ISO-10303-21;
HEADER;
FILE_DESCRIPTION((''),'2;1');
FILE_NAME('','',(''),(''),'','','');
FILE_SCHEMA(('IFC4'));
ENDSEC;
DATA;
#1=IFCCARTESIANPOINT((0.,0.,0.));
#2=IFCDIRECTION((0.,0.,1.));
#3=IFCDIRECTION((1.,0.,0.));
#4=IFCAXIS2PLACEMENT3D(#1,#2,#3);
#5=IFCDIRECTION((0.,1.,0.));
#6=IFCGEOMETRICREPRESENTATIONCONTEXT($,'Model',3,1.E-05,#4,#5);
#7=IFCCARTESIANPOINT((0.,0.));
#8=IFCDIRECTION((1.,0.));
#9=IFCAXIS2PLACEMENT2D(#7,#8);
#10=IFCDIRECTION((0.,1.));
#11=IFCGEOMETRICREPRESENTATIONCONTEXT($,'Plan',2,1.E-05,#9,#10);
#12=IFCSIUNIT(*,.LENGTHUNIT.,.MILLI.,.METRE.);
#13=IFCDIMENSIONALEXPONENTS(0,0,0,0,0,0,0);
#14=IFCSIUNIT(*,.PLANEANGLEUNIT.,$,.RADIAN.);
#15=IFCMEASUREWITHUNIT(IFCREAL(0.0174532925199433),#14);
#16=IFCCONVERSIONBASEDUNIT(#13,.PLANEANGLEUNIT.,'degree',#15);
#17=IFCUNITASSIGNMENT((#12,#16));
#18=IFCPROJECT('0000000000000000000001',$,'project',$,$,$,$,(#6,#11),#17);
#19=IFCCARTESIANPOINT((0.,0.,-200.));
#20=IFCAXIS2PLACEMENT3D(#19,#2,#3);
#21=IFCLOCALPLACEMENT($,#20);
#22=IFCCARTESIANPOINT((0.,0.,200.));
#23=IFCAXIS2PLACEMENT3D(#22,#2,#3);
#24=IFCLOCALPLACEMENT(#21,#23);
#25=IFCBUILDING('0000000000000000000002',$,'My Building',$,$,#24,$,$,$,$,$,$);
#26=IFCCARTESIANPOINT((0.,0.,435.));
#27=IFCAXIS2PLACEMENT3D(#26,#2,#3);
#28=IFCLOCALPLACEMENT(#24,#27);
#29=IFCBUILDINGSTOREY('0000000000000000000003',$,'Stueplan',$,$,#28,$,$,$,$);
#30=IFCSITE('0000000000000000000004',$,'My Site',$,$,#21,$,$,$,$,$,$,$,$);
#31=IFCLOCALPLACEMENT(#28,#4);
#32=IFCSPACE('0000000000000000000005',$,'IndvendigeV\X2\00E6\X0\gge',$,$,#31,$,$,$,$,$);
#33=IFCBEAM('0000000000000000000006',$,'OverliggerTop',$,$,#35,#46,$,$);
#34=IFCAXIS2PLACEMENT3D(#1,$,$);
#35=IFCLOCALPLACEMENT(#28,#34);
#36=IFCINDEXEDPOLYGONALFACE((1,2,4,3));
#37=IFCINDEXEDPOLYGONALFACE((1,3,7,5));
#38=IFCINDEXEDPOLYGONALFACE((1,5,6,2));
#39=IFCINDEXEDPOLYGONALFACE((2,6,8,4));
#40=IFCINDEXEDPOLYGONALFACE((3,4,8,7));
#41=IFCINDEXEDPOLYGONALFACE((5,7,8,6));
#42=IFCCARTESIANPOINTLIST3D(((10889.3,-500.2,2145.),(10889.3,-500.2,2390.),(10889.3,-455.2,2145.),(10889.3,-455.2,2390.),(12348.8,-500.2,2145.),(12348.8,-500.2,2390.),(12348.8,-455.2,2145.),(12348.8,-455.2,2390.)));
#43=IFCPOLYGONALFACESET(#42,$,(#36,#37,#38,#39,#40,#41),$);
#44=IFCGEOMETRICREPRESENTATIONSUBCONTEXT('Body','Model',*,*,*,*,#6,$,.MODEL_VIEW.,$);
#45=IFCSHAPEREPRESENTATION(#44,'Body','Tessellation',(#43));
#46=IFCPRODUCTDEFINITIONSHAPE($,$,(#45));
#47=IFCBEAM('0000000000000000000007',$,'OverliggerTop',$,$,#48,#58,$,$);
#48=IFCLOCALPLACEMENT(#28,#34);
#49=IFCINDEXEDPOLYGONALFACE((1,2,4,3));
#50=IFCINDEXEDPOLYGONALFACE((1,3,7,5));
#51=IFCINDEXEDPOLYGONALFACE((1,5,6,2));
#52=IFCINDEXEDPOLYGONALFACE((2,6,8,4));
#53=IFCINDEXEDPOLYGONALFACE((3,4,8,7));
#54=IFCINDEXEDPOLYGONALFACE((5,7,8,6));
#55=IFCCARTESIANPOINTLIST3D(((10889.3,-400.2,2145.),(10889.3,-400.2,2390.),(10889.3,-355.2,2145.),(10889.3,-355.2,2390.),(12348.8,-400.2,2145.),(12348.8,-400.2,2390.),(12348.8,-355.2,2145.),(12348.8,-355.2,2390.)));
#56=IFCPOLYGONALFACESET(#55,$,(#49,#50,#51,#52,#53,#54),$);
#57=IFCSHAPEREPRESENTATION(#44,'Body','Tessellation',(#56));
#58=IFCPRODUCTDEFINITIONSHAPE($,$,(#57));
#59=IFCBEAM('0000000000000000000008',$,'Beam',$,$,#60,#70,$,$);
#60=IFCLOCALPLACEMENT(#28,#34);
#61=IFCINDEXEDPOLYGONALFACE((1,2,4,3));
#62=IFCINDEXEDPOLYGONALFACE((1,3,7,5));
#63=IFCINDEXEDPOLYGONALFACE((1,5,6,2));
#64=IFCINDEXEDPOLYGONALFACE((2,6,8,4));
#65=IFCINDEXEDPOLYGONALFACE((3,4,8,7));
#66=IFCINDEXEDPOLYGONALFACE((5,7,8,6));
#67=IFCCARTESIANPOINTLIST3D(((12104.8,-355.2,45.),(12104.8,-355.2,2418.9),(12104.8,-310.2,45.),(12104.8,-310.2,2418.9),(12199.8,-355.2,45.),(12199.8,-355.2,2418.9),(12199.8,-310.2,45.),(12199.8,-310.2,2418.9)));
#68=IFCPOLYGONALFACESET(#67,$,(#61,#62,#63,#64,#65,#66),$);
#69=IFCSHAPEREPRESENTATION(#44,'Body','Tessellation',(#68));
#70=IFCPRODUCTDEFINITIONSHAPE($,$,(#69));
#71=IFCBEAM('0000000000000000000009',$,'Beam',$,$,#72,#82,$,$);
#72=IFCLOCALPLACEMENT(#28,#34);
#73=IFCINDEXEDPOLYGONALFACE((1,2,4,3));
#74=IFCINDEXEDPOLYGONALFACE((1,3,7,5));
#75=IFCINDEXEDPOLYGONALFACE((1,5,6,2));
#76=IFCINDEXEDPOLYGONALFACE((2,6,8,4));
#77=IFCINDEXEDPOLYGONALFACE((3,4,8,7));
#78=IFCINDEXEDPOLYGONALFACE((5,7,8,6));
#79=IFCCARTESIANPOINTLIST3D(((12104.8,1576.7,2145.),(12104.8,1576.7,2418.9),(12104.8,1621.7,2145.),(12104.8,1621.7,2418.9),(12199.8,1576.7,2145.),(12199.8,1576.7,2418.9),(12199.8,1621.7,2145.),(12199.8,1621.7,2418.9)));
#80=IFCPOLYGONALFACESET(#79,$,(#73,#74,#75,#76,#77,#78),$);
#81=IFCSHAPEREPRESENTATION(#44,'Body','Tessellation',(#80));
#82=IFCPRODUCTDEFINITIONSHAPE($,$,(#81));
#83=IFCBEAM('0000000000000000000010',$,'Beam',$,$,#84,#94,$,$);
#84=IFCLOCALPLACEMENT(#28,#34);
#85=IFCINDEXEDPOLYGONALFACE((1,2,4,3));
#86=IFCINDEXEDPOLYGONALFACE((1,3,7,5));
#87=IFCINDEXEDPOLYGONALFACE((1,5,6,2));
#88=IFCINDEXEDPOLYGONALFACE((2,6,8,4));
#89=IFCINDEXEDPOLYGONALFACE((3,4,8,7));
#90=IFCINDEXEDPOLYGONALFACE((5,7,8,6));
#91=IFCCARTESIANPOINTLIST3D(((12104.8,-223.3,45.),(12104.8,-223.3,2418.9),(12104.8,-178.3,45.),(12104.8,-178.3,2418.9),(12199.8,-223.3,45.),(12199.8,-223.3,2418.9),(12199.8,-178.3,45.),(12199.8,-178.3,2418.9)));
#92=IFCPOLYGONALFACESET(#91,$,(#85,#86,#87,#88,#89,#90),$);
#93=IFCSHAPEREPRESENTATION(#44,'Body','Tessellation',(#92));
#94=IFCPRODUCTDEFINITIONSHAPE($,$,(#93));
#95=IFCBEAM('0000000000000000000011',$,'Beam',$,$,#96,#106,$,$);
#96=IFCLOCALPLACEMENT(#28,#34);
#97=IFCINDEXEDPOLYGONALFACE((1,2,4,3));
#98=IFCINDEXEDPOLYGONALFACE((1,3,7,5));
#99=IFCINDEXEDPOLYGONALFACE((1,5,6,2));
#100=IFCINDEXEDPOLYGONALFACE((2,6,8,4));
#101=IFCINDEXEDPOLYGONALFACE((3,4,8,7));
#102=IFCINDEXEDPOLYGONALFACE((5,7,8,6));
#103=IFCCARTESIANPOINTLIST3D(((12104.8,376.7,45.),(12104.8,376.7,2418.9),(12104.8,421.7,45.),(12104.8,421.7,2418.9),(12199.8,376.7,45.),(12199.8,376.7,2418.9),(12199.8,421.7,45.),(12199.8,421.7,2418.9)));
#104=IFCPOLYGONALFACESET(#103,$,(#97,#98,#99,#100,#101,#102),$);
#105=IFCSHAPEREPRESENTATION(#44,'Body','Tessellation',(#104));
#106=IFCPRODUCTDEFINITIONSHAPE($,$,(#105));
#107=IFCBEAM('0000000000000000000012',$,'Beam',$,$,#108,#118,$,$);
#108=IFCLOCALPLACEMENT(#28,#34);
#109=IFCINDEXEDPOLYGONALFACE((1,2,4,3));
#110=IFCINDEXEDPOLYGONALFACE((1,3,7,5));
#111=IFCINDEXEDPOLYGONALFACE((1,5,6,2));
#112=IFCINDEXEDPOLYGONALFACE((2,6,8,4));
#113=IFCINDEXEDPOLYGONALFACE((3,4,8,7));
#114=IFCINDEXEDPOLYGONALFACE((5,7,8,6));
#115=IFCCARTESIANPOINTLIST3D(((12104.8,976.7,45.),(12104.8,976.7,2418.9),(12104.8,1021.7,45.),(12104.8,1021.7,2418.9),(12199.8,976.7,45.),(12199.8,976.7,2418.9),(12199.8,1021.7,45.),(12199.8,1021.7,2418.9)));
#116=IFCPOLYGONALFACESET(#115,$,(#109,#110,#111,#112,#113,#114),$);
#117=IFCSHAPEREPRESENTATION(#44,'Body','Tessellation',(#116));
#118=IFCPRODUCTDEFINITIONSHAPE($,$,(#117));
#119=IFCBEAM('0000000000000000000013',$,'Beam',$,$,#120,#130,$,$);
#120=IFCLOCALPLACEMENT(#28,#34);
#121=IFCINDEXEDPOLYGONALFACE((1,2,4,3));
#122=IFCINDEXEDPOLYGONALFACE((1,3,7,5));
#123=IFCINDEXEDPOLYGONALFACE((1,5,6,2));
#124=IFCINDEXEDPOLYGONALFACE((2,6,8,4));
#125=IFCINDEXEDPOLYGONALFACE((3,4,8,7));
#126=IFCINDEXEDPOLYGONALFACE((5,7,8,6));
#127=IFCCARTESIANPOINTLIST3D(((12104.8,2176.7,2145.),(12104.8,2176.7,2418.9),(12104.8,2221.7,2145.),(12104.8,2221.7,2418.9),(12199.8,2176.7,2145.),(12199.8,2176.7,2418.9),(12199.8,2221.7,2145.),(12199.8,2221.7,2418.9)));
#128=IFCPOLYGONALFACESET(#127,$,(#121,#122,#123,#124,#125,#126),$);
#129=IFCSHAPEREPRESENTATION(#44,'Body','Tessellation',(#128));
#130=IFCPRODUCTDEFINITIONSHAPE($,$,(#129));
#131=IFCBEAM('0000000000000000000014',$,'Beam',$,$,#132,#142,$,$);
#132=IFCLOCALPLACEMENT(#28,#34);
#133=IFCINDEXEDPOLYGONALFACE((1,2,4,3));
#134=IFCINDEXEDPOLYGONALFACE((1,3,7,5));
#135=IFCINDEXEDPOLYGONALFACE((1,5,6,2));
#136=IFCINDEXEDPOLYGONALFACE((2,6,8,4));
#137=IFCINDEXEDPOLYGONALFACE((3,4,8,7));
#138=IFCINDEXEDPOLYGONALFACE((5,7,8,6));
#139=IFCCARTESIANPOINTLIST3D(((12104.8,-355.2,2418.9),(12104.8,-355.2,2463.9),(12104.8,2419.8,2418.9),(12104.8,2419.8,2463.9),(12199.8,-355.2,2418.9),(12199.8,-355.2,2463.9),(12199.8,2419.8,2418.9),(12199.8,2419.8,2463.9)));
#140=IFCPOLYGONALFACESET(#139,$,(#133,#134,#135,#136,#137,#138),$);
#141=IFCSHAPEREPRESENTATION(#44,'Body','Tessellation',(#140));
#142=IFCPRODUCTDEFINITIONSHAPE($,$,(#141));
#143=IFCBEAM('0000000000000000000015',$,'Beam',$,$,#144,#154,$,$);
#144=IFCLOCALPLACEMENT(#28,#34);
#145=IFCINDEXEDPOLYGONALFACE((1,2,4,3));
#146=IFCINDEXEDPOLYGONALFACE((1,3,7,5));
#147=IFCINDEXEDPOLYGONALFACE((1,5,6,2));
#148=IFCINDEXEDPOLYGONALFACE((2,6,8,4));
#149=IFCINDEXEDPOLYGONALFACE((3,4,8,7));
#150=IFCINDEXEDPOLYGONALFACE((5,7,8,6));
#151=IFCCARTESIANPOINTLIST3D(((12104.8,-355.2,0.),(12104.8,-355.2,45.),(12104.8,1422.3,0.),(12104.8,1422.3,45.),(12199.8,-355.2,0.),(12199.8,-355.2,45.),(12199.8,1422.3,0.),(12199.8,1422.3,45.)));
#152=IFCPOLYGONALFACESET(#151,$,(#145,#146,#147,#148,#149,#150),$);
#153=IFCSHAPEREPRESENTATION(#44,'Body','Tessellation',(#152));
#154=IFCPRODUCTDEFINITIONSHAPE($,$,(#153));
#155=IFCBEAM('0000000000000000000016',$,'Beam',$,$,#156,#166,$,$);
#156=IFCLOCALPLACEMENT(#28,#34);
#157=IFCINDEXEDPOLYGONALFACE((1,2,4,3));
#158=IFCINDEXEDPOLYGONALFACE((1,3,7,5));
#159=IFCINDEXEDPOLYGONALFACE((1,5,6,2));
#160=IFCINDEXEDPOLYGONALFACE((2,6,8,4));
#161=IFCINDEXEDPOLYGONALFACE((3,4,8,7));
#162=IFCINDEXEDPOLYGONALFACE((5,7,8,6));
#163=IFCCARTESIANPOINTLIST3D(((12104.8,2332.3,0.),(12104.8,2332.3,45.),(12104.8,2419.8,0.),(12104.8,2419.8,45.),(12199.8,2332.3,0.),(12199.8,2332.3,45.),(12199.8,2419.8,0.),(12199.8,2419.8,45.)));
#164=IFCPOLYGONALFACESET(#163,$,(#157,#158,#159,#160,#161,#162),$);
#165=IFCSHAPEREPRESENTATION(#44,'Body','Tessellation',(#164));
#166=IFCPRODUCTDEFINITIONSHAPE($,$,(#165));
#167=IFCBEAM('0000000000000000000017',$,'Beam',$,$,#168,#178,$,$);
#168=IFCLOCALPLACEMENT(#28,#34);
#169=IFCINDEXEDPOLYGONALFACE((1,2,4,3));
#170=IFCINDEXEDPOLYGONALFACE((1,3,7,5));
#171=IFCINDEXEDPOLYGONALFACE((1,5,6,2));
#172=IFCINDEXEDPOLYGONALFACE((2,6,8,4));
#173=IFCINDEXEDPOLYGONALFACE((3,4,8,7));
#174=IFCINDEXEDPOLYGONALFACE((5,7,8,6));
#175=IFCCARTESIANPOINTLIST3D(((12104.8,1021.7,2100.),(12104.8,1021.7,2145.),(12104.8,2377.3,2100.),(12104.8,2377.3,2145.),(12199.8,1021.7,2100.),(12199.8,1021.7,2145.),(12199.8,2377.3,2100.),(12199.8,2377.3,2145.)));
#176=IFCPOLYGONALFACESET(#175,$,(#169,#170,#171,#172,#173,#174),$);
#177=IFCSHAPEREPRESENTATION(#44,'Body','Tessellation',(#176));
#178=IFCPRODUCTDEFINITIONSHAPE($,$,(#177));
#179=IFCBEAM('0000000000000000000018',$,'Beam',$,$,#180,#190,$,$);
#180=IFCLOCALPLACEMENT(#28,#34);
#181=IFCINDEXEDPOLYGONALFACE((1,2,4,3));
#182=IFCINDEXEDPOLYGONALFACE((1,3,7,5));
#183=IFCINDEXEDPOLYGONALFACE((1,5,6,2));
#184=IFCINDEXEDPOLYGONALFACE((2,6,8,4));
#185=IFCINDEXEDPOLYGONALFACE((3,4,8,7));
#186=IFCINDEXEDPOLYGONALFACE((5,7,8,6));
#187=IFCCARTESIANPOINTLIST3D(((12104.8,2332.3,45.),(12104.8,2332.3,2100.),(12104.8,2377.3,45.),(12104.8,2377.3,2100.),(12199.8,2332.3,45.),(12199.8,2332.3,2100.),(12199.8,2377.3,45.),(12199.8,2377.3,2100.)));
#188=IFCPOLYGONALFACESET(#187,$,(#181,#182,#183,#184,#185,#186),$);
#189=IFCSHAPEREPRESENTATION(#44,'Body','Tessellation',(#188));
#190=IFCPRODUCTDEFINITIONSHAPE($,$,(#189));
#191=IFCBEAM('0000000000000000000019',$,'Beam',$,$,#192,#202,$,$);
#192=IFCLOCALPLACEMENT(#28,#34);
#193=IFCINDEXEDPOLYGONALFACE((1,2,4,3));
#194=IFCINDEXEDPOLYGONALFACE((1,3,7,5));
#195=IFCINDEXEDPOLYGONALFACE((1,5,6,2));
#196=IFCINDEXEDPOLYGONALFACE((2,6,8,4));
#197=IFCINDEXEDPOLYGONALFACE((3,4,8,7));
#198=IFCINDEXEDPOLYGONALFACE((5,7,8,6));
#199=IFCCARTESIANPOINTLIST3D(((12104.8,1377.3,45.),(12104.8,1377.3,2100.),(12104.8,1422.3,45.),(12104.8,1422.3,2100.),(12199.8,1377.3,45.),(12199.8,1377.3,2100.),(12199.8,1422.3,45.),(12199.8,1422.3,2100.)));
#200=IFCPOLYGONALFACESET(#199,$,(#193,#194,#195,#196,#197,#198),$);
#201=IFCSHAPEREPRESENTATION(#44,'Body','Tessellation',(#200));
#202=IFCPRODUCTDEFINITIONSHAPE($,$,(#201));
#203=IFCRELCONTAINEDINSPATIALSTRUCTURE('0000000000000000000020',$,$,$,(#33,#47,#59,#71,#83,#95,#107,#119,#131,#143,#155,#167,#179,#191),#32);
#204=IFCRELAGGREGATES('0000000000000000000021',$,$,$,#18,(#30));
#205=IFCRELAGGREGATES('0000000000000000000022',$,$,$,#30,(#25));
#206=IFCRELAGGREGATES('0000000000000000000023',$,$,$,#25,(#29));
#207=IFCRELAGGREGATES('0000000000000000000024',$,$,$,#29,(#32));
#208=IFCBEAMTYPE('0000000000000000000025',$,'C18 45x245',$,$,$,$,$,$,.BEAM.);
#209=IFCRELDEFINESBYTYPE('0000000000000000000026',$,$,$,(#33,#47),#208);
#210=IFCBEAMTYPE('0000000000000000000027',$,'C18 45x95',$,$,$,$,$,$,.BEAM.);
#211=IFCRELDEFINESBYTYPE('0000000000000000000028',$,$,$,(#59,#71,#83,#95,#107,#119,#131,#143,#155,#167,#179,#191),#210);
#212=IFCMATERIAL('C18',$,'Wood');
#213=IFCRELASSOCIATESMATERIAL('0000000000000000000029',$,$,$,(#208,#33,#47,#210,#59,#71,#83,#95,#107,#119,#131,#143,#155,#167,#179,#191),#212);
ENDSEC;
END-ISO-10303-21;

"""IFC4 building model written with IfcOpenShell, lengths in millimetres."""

from ifc_helpers import new_model, entity, si_unit, converted_unit, direction, frame, origin_with_axes, origin_2d_with_axis, place, context, subcontext, project, spatial, rectangle, extrude, material, material_profile, profile_set, profile_usage, type_object, element, save


model = new_model("IFC4")

# Units and contexts
model_context = context("Model", 3, precision=1e-05, world=origin_with_axes(), true_north=direction((0.0, 1.0, 0.0)))
plan_context = context("Plan", 2, precision=1e-05, world=origin_2d_with_axis(), true_north=direction((0.0, 1.0)))
body_context_1 = subcontext(model_context, "Body", "Model", "MODEL_VIEW")
ifc_project = project(units=[si_unit("LENGTHUNIT", "METRE", prefix="MILLI"), converted_unit("PLANEANGLEUNIT", "degree", entity("IfcReal", 0.0174532925199433), si_unit("PLANEANGLEUNIT", "RADIAN"), dimensions=[0, 0, 0, 0, 0, 0, 0])], contexts=[model_context, plan_context])

# Site, building, storey
site_placement = place(None, frame((0.0, 0.0, -200.0), z_axis=(0.0, 0.0, 1.0), x_axis=(1.0, 0.0, 0.0)))
site = spatial("IfcSite", under=ifc_project, at=site_placement, Name="My Site")
building_placement = place(site_placement, frame((0.0, 0.0, 200.0), z_axis=(0.0, 0.0, 1.0), x_axis=(1.0, 0.0, 0.0)))
building = spatial("IfcBuilding", under=site, at=building_placement, Name="My Building")
storey_placement = place(building_placement, frame((0.0, 0.0, 435.0), z_axis=(0.0, 0.0, 1.0), x_axis=(1.0, 0.0, 0.0)))
storey = spatial("IfcBuildingStorey", under=building, at=storey_placement, Name="Stueplan")

# Shared definitions
ifc_material = material(Name="C18", Category="Wood")

# Shared definitions
space_1_placement = place(storey_placement, frame((0.0, 0.0, 0.0), z_axis=(0.0, 0.0, 1.0), x_axis=(1.0, 0.0, 0.0)))
space_1 = spatial("IfcSpace", under=storey, at=space_1_placement, Name="IndvendigeVægge")

# Beams
ifc_material_profile_1 = material_profile(ifc_material, rectangle(XDim=45.0, YDim=245.0), Name="concrete")
ifc_profile_set_1 = profile_set([ifc_material_profile_1], Name="woodStructural")
ifc_profile_usage_1 = profile_usage(ifc_profile_set_1)
beam_type_1 = type_object("IfcBeamType", Name="C18 45x245", PredefinedType="BEAM", material=ifc_profile_set_1)
beam_1_placement = place(space_1_placement, frame((12348.8, -477.7, 2267.5), z_axis=(-1.0, 0.0, 0.0), x_axis=(0.0, 1.0, 0.0)))
element("IfcBeam", 1, at=beam_1_placement, inside=space_1, type_object=beam_type_1, material=ifc_profile_usage_1, Name="OverliggerTop", context=body_context_1, shape_type="SweptSolid", body=[
    extrude(rectangle(XDim=45.0, YDim=245.0), origin_with_axes(), (0.0, 0.0, 1.0), 1459.5),
])
ifc_profile_usage_2 = profile_usage(ifc_profile_set_1)
beam_2_placement = place(space_1_placement, frame((12348.8, -377.7, 2267.5), z_axis=(-1.0, 0.0, 0.0), x_axis=(0.0, 1.0, 0.0)))
element("IfcBeam", 2, at=beam_2_placement, inside=space_1, type_object=beam_type_1, material=ifc_profile_usage_2, Name="OverliggerTop", context=body_context_1, shape_type="SweptSolid", body=[
    extrude(rectangle(XDim=45.0, YDim=245.0), origin_with_axes(), (0.0, 0.0, 1.0), 1459.5),
])
ifc_material_profile_2 = material_profile(ifc_material, rectangle(XDim=45.0, YDim=95.0))
ifc_profile_set_2 = profile_set([ifc_material_profile_2], Name="woodStructural")
ifc_profile_usage_3 = profile_usage(ifc_profile_set_2)
beam_type_2 = type_object("IfcBeamType", Name="C18 45x95", PredefinedType="BEAM", material=ifc_profile_set_2)
beam_3_placement = place(space_1_placement, frame((12152.3, -332.7, 45.0), z_axis=(0.0, 0.0, 1.0), x_axis=(0.0, -1.0, 0.0)))
element("IfcBeam", 3, at=beam_3_placement, inside=space_1, type_object=beam_type_2, material=ifc_profile_usage_3, Name="Beam", context=body_context_1, shape_type="SweptSolid", body=[
    extrude(rectangle(XDim=45.0, YDim=95.0), origin_with_axes(), (0.0, 0.0, 1.0), 2373.9),
])
ifc_profile_usage_4 = profile_usage(ifc_profile_set_2)
beam_4_placement = place(space_1_placement, frame((12152.3, 1599.2, 2145.0), z_axis=(0.0, 0.0, 1.0), x_axis=(0.0, -1.0, 0.0)))
element("IfcBeam", 4, at=beam_4_placement, inside=space_1, type_object=beam_type_2, material=ifc_profile_usage_4, Name="Beam", context=body_context_1, shape_type="SweptSolid", body=[
    extrude(rectangle(XDim=45.0, YDim=95.0), origin_with_axes(), (0.0, 0.0, 1.0), 273.9),
])
ifc_profile_usage_5 = profile_usage(ifc_profile_set_2)
beam_5_placement = place(space_1_placement, frame((12152.3, -200.8, 45.0), z_axis=(0.0, 0.0, 1.0), x_axis=(0.0, -1.0, 0.0)))
element("IfcBeam", 5, at=beam_5_placement, inside=space_1, type_object=beam_type_2, material=ifc_profile_usage_5, Name="Beam", context=body_context_1, shape_type="SweptSolid", body=[
    extrude(rectangle(XDim=45.0, YDim=95.0), origin_with_axes(), (0.0, 0.0, 1.0), 2373.9),
])
ifc_profile_usage_6 = profile_usage(ifc_profile_set_2)
beam_6_placement = place(space_1_placement, frame((12152.3, 399.2, 45.0), z_axis=(0.0, 0.0, 1.0), x_axis=(0.0, -1.0, 0.0)))
element("IfcBeam", 6, at=beam_6_placement, inside=space_1, type_object=beam_type_2, material=ifc_profile_usage_6, Name="Beam", context=body_context_1, shape_type="SweptSolid", body=[
    extrude(rectangle(XDim=45.0, YDim=95.0), origin_with_axes(), (0.0, 0.0, 1.0), 2373.9),
])
ifc_profile_usage_7 = profile_usage(ifc_profile_set_2)
beam_7_placement = place(space_1_placement, frame((12152.3, 999.2, 45.0), z_axis=(0.0, 0.0, 1.0), x_axis=(0.0, -1.0, 0.0)))
element("IfcBeam", 7, at=beam_7_placement, inside=space_1, type_object=beam_type_2, material=ifc_profile_usage_7, Name="Beam", context=body_context_1, shape_type="SweptSolid", body=[
    extrude(rectangle(XDim=45.0, YDim=95.0), origin_with_axes(), (0.0, 0.0, 1.0), 2373.9),
])
ifc_profile_usage_8 = profile_usage(ifc_profile_set_2)
beam_8_placement = place(space_1_placement, frame((12152.3, 2199.2, 2145.0), z_axis=(0.0, 0.0, 1.0), x_axis=(0.0, -1.0, 0.0)))
element("IfcBeam", 8, at=beam_8_placement, inside=space_1, type_object=beam_type_2, material=ifc_profile_usage_8, Name="Beam", context=body_context_1, shape_type="SweptSolid", body=[
    extrude(rectangle(XDim=45.0, YDim=95.0), origin_with_axes(), (0.0, 0.0, 1.0), 273.9),
])
ifc_profile_usage_9 = profile_usage(ifc_profile_set_2, cardinal=5)
beam_9_placement = place(space_1_placement, frame((12152.3, -355.2, 2441.4), z_axis=(0.0, 1.0, 0.0), x_axis=(0.0, 0.0, 1.0)))
element("IfcBeam", 9, at=beam_9_placement, inside=space_1, type_object=beam_type_2, material=ifc_profile_usage_9, Name="Beam", context=body_context_1, shape_type="SweptSolid", body=[
    extrude(rectangle(XDim=45.0, YDim=95.0), origin_with_axes(), (0.0, 0.0, 1.0), 2775.0),
])
ifc_profile_usage_10 = profile_usage(ifc_profile_set_2, cardinal=5)
beam_10_placement = place(space_1_placement, frame((12152.3, -355.2, 22.5), z_axis=(0.0, 1.0, 0.0), x_axis=(0.0, 0.0, 1.0)))
element("IfcBeam", 10, at=beam_10_placement, inside=space_1, type_object=beam_type_2, material=ifc_profile_usage_10, Name="Beam", context=body_context_1, shape_type="SweptSolid", body=[
    extrude(rectangle(XDim=45.0, YDim=95.0), origin_with_axes(), (0.0, 0.0, 1.0), 1777.5),
])
ifc_profile_usage_11 = profile_usage(ifc_profile_set_2, cardinal=5)
beam_11_placement = place(space_1_placement, frame((12152.3, 2332.3, 22.5), z_axis=(0.0, 1.0, 0.0), x_axis=(0.0, 0.0, 1.0)))
element("IfcBeam", 11, at=beam_11_placement, inside=space_1, type_object=beam_type_2, material=ifc_profile_usage_11, Name="Beam", context=body_context_1, shape_type="SweptSolid", body=[
    extrude(rectangle(XDim=45.0, YDim=95.0), origin_with_axes(), (0.0, 0.0, 1.0), 87.5),
])
ifc_profile_usage_12 = profile_usage(ifc_profile_set_2, cardinal=5)
beam_12_placement = place(space_1_placement, frame((12152.3, 1021.7, 2122.5), z_axis=(0.0, 1.0, 0.0), x_axis=(0.0, 0.0, 1.0)))
element("IfcBeam", 12, at=beam_12_placement, inside=space_1, type_object=beam_type_2, material=ifc_profile_usage_12, Name="Beam", context=body_context_1, shape_type="SweptSolid", body=[
    extrude(rectangle(XDim=45.0, YDim=95.0), origin_with_axes(), (0.0, 0.0, 1.0), 1355.6),
])
ifc_profile_usage_13 = profile_usage(ifc_profile_set_2)
beam_13_placement = place(space_1_placement, frame((12152.3, 2354.8, 45.0), z_axis=(0.0, 0.0, 1.0), x_axis=(0.0, 1.0, 0.0)))
element("IfcBeam", 13, at=beam_13_placement, inside=space_1, type_object=beam_type_2, material=ifc_profile_usage_13, Name="Beam", context=body_context_1, shape_type="SweptSolid", body=[
    extrude(rectangle(XDim=45.0, YDim=95.0), origin_with_axes(), (0.0, 0.0, 1.0), 2055.0),
])
ifc_profile_usage_14 = profile_usage(ifc_profile_set_2)
beam_14_placement = place(space_1_placement, frame((12152.3, 1399.8, 45.0), z_axis=(0.0, 0.0, 1.0), x_axis=(0.0, 1.0, 0.0)))
element("IfcBeam", 14, at=beam_14_placement, inside=space_1, type_object=beam_type_2, material=ifc_profile_usage_14, Name="Beam", context=body_context_1, shape_type="SweptSolid", body=[
    extrude(rectangle(XDim=45.0, YDim=95.0), origin_with_axes(), (0.0, 0.0, 1.0), 2055.0),
])

save(model, "model.ifc")
